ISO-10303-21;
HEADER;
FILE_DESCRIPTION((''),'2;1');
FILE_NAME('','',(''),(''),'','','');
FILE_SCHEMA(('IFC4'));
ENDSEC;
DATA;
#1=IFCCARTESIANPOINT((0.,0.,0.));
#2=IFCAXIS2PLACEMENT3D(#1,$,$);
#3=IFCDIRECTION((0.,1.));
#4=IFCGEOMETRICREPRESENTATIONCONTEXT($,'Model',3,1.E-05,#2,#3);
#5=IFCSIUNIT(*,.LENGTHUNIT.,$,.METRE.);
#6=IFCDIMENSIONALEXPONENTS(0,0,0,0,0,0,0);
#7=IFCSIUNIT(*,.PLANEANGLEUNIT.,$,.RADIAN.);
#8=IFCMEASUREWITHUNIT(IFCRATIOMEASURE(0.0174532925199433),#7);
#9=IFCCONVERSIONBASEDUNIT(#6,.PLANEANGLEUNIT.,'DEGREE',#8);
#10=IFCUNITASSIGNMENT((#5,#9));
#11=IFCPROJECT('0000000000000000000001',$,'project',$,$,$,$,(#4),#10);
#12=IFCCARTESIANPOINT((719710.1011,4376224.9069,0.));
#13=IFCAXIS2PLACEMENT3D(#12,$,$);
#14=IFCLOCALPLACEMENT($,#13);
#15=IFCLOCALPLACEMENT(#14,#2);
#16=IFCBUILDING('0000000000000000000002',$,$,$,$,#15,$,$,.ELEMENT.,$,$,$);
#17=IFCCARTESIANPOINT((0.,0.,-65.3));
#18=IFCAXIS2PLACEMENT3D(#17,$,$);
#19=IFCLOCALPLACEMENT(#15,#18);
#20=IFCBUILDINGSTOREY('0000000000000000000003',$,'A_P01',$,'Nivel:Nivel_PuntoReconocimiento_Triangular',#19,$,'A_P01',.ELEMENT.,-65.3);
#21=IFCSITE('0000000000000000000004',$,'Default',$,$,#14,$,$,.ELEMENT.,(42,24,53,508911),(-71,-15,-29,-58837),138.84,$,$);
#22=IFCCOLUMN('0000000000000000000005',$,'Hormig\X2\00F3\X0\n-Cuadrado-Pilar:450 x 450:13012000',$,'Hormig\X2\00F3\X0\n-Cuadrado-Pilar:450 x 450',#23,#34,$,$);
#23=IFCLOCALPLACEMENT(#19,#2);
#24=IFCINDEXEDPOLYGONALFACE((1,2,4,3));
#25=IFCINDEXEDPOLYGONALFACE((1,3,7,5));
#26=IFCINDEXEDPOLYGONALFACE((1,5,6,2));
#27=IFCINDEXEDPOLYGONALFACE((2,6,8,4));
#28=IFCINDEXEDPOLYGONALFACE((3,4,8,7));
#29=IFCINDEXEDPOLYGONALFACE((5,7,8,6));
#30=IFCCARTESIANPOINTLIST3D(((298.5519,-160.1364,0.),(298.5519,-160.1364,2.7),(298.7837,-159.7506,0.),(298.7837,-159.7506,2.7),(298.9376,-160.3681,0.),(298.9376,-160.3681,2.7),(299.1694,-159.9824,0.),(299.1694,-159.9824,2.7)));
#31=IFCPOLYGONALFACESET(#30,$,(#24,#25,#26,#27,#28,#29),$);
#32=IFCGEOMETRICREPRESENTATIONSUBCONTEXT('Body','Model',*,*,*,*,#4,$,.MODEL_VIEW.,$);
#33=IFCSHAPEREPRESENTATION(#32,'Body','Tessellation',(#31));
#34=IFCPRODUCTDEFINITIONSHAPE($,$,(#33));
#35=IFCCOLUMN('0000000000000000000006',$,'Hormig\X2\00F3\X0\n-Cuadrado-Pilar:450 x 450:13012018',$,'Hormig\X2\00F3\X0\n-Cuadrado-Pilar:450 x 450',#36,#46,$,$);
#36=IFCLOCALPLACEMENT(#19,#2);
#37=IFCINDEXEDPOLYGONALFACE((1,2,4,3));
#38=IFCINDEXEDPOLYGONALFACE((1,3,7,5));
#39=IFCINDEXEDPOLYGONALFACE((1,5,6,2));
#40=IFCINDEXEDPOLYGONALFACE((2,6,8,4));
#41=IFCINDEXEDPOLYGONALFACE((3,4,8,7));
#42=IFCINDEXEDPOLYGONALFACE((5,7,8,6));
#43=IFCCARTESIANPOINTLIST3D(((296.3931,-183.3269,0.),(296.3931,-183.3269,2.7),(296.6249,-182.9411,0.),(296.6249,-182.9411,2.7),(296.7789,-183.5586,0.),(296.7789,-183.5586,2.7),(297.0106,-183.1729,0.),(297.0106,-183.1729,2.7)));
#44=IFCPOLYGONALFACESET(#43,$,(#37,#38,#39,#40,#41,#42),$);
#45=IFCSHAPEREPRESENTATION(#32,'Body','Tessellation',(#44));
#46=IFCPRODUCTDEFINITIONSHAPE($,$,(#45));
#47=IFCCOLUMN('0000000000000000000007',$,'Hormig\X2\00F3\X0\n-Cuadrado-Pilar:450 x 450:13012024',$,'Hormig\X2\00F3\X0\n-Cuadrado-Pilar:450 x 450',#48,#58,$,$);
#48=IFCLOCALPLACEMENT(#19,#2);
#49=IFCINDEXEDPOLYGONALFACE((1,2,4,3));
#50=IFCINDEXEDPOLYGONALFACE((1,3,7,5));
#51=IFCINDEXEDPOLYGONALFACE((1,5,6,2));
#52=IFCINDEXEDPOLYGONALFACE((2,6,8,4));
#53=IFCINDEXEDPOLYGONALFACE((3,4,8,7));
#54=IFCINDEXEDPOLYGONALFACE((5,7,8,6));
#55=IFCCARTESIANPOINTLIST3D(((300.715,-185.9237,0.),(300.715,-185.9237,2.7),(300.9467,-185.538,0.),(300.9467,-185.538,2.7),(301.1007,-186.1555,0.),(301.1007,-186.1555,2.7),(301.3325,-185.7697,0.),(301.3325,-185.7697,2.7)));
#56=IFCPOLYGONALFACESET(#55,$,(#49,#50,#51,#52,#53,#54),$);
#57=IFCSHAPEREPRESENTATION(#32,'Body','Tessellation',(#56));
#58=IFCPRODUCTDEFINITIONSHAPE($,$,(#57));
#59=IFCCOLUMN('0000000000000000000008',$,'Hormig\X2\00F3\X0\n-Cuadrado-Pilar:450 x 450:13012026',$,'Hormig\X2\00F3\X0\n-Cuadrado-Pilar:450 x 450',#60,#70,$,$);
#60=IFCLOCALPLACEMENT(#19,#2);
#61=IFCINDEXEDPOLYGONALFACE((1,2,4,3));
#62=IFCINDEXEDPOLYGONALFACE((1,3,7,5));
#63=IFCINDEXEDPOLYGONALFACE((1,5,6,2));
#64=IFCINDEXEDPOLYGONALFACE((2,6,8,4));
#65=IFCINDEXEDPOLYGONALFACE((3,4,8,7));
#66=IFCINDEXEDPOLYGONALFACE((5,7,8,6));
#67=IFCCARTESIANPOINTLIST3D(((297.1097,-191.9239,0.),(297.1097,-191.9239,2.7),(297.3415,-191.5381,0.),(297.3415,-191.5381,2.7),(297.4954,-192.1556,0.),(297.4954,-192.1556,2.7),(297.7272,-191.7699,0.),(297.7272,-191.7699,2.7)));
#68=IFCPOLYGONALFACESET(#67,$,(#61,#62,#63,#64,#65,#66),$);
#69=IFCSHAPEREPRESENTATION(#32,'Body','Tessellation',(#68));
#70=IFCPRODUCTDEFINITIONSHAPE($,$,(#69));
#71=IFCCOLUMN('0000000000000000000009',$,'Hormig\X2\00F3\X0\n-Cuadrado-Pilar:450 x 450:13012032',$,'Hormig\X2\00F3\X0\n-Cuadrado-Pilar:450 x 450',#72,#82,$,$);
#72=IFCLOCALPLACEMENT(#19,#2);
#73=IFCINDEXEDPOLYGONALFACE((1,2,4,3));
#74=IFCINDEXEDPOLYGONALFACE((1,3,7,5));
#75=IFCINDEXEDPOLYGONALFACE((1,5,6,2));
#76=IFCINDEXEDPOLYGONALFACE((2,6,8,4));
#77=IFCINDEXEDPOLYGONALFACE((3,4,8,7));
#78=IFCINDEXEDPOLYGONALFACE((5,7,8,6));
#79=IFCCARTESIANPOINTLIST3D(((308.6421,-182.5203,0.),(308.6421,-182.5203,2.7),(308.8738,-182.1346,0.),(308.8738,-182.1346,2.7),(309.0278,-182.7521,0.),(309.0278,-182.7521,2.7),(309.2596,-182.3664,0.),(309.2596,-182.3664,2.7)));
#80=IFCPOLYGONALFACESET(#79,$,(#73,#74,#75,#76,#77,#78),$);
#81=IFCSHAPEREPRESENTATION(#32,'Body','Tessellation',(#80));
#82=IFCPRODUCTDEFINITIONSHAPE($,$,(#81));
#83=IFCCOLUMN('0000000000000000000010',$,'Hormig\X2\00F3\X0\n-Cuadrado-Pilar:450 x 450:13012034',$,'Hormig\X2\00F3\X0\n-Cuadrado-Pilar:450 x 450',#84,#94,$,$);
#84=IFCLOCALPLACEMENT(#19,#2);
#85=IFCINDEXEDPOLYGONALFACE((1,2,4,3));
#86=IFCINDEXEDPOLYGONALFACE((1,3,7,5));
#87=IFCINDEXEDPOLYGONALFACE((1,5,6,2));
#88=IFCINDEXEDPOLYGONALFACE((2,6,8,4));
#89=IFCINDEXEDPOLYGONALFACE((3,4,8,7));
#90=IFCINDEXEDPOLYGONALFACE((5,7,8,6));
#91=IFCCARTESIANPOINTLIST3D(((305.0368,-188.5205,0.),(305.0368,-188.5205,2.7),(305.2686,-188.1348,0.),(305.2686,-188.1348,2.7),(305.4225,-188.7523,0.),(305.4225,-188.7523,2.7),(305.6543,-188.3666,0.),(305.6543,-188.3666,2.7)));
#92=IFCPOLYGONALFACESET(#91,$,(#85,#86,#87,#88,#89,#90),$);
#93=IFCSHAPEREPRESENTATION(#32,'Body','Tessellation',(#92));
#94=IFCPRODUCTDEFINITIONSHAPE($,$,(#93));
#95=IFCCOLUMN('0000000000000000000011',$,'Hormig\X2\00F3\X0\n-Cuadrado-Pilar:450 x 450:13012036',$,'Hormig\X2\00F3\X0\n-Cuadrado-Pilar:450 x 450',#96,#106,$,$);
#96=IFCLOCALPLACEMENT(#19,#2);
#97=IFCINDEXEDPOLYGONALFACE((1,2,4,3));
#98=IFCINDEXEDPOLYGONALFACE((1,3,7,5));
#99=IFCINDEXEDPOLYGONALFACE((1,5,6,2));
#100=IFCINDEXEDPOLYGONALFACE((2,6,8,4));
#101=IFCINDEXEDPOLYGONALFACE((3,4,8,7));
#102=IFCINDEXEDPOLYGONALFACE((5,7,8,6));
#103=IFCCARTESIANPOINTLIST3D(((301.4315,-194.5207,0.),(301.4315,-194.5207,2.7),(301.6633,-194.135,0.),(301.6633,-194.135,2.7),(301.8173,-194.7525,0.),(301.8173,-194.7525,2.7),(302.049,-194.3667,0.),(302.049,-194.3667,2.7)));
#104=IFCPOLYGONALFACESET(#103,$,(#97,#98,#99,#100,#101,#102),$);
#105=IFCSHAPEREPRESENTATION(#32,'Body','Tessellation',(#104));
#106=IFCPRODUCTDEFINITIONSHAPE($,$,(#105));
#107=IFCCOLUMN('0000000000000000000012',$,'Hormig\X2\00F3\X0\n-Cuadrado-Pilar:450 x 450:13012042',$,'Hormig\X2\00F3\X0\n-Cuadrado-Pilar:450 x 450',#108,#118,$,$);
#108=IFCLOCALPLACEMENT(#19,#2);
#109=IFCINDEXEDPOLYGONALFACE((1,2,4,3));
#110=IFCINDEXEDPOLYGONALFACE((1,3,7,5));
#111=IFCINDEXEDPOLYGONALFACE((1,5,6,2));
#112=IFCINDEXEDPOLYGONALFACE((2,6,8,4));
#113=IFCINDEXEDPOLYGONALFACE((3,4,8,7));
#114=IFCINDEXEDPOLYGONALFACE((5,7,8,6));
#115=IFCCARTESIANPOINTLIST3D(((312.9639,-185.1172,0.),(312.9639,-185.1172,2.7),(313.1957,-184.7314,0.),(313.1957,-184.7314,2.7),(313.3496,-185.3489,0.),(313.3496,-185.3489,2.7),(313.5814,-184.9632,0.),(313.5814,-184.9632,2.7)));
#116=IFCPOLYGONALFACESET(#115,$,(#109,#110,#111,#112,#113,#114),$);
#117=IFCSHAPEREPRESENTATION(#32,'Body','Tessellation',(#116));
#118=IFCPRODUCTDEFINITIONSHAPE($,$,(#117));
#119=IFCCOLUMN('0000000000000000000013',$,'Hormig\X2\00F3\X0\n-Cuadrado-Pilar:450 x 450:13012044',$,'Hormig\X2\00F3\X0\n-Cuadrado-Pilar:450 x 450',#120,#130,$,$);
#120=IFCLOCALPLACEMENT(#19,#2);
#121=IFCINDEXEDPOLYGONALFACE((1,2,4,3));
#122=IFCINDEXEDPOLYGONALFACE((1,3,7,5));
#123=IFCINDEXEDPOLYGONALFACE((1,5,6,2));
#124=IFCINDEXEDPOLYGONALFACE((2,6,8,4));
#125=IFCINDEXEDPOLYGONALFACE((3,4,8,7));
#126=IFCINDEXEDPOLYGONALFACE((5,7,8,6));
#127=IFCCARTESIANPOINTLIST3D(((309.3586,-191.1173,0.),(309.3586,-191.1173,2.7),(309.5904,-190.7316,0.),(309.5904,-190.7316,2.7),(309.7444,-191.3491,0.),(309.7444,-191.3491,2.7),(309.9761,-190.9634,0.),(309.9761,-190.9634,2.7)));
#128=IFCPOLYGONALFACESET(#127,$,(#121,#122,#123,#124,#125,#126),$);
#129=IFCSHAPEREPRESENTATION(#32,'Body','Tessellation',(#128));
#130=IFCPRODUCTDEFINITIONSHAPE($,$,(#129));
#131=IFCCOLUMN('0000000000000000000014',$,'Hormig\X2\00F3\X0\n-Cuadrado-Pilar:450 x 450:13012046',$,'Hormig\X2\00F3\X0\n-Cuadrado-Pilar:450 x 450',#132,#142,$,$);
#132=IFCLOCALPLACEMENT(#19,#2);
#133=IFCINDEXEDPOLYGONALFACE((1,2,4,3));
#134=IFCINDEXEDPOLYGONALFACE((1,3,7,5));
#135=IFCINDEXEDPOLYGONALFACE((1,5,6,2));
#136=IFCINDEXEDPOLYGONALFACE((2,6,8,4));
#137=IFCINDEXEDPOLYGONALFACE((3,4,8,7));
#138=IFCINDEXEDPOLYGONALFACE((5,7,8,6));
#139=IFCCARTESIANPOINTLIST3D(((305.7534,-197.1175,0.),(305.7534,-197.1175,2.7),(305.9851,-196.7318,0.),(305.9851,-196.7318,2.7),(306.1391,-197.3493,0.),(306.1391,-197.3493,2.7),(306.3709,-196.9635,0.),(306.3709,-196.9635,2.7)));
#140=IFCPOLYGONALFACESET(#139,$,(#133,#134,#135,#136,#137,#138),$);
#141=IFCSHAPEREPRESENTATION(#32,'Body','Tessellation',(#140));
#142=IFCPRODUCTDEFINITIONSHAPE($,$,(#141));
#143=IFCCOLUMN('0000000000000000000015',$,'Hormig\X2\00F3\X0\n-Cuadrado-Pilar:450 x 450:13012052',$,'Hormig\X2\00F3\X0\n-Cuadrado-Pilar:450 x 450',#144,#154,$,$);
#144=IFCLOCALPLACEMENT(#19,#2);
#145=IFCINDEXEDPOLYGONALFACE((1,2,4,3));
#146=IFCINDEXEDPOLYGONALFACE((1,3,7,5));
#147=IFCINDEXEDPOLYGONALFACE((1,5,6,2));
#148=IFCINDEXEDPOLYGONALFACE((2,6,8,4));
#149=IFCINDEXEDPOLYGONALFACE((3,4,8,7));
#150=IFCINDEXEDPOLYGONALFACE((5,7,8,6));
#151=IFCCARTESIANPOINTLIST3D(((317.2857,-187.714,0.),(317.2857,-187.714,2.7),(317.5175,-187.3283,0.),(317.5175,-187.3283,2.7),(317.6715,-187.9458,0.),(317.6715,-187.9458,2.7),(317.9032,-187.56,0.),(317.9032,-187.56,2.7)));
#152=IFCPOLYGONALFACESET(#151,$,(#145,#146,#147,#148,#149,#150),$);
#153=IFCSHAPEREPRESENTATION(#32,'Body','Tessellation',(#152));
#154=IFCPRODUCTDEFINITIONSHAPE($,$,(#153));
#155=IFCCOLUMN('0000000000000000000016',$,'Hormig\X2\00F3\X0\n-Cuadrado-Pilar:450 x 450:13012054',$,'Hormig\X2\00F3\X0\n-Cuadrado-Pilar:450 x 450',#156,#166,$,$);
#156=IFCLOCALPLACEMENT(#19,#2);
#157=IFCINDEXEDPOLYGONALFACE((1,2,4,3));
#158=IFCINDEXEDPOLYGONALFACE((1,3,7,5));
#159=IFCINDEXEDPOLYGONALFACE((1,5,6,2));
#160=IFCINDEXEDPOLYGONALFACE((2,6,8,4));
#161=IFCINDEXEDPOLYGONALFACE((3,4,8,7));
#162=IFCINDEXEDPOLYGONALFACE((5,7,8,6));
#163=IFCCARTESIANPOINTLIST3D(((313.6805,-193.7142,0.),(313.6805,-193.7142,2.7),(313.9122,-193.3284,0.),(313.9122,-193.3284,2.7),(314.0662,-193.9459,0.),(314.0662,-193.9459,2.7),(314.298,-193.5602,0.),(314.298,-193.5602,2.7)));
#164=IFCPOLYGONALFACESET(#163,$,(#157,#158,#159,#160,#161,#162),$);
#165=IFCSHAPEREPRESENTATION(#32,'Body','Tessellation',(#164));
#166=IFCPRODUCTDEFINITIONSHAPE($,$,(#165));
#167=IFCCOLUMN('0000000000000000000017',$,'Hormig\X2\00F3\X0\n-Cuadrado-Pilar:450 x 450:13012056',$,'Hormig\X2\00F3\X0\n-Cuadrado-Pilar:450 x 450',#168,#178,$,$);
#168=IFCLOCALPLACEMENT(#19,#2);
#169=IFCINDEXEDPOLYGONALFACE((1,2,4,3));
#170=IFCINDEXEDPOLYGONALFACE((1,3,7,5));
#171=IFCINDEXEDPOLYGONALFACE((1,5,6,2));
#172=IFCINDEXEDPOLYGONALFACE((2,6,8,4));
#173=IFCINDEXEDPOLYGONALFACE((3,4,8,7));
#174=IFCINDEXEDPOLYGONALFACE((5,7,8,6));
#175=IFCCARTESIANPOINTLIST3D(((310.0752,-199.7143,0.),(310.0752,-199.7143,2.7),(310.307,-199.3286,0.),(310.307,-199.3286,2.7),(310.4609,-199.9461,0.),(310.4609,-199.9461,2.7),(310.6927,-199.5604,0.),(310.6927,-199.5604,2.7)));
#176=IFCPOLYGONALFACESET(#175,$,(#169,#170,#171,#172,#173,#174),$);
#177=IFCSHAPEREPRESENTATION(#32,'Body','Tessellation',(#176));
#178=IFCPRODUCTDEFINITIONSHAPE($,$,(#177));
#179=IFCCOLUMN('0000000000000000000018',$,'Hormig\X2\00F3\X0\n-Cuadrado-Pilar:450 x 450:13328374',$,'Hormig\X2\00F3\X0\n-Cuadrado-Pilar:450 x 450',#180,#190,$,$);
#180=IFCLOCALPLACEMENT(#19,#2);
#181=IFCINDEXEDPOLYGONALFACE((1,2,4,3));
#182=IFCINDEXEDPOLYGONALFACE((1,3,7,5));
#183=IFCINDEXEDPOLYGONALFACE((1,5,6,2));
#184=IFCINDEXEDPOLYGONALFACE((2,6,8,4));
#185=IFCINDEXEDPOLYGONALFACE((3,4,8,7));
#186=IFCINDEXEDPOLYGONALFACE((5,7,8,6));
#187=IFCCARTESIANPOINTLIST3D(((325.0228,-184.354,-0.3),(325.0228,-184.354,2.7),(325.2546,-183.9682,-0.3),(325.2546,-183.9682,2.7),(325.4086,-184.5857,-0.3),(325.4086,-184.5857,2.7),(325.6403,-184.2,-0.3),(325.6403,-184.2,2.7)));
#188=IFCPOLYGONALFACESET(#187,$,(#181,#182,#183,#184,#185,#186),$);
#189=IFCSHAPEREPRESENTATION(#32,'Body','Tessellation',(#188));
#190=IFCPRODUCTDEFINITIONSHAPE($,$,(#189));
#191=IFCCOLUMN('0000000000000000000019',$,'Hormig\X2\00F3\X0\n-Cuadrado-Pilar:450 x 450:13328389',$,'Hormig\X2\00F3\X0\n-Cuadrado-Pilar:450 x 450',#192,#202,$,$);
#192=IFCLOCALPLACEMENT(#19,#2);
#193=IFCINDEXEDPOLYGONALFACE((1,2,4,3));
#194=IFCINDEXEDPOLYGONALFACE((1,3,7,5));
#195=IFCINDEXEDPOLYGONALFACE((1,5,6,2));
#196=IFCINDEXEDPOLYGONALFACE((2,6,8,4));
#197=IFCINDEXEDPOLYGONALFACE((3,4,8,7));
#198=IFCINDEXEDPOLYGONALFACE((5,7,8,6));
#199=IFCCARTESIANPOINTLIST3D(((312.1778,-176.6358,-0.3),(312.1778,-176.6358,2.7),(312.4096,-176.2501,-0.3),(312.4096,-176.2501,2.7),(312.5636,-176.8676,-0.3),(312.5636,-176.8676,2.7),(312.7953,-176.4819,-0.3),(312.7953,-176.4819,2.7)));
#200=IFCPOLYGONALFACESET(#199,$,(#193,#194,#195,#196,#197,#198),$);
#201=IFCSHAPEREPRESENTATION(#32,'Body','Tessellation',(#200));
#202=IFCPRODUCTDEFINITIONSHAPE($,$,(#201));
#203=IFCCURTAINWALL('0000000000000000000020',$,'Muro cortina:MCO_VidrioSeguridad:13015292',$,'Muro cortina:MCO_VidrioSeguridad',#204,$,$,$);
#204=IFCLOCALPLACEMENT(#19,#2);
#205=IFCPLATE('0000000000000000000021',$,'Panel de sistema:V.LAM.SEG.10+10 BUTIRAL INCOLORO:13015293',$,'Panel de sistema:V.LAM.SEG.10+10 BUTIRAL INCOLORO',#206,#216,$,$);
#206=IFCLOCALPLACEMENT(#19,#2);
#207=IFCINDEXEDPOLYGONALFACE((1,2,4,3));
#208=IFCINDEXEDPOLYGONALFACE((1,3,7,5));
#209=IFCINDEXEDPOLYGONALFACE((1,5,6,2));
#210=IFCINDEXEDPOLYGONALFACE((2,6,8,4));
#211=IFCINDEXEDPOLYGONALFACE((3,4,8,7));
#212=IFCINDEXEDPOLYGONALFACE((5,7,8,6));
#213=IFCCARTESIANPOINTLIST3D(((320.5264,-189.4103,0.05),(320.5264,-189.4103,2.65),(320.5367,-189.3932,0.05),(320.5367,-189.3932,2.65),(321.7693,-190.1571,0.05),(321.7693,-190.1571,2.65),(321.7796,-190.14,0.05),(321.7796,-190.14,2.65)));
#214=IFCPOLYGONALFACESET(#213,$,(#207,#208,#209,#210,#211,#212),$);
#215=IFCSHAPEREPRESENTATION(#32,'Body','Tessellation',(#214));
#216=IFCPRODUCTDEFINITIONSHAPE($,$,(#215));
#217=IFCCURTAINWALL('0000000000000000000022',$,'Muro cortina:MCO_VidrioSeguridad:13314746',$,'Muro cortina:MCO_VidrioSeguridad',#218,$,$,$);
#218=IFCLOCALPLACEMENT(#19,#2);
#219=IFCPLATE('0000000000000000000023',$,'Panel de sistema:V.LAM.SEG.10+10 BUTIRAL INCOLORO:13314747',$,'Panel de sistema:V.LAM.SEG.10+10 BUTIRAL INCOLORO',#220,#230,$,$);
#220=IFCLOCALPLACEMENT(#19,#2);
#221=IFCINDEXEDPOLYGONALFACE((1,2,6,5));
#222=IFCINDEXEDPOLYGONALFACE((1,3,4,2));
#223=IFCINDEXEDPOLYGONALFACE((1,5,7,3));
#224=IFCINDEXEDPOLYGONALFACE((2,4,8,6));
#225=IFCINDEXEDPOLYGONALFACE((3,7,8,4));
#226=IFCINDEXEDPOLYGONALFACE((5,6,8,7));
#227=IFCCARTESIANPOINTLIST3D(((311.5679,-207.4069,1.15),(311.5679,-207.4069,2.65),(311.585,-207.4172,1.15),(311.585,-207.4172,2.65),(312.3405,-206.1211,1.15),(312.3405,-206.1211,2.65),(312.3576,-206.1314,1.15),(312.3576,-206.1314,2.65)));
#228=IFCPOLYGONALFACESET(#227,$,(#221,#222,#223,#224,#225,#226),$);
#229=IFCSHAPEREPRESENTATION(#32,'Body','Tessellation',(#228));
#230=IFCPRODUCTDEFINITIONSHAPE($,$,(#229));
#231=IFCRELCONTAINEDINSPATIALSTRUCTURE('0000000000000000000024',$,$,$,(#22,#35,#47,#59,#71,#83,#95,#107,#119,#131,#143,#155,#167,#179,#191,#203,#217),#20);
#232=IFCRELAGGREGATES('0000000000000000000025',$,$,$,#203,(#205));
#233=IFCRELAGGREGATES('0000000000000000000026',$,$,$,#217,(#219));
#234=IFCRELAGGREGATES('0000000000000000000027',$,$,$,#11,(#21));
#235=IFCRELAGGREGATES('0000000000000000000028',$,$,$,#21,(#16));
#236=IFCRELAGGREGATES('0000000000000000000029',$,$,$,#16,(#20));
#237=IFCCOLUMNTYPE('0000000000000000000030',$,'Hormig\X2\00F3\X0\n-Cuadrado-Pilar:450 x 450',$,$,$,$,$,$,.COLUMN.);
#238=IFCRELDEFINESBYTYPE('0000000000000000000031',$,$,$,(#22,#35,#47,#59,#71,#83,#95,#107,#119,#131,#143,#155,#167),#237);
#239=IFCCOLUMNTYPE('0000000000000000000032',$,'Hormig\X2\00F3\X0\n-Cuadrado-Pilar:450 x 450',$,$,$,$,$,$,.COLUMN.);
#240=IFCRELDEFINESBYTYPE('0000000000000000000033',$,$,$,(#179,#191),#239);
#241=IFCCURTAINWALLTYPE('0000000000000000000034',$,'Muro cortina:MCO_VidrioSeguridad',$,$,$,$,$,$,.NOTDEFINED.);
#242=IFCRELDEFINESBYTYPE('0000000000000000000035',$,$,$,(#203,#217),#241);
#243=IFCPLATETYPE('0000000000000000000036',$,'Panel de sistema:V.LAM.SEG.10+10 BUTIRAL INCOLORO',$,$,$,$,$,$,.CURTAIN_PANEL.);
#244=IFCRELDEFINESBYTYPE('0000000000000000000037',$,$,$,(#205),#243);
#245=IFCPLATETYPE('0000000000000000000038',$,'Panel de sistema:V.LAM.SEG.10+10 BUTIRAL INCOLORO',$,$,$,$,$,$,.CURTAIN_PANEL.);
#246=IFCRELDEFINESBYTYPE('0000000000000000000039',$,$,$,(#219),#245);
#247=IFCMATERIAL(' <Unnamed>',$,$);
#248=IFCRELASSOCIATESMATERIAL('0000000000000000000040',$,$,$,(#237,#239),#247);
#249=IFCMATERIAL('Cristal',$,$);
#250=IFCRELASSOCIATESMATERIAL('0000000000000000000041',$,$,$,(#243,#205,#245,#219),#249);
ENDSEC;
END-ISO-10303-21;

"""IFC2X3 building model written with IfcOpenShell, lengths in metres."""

from ifc_helpers import new_model, entity, si_unit, converted_unit, direction, frame, frame_2d, origin, origin_2d_with_axis, place, context, subcontext, project, spatial, rectangle, extrude, source, transform, mapped, material, type_object, type_shapes, element, aggregate, save


model = new_model("IFC2X3")

# Units and contexts
model_context = context("Model", 3, precision=1e-05, world=origin(), true_north=direction((0.0, 1.0)))
body_context = subcontext(model_context, "Body", "Model", "MODEL_VIEW")
ifc_project = project(units=[si_unit("LENGTHUNIT", "METRE"), converted_unit("PLANEANGLEUNIT", "DEGREE", entity("IfcRatioMeasure", 0.0174532925199433), si_unit("PLANEANGLEUNIT", "RADIAN"), dimensions=[0, 0, 0, 0, 0, 0, 0])], contexts=[model_context])

# Site, building, storey
site_placement = place(None, frame((719710.1011, 4376224.9069, 0.0)))
site = spatial("IfcSite", under=ifc_project, at=site_placement, Name="Default", CompositionType="ELEMENT", RefLatitude=(42, 24, 53, 508911), RefLongitude=(-71, -15, -29, -58837), RefElevation=138.84)
building_placement = place(site_placement, origin())
building = spatial("IfcBuilding", under=site, at=building_placement, CompositionType="ELEMENT")
storey_placement = place(building_placement, frame((0.0, 0.0, -65.3)))
storey = spatial("IfcBuildingStorey", under=building, at=storey_placement, Name="A_P01", ObjectType="Nivel:Nivel_PuntoReconocimiento_Triangular", LongName="A_P01", CompositionType="ELEMENT", Elevation=-65.3)

# Columns
ifc_material_1 = material(Name=" <Unnamed>")
column_type_1 = type_object("IfcColumnType", Name="Hormigón-Cuadrado-Pilar:450 x 450", PredefinedType="COLUMN", material=ifc_material_1)
shared_shape_1 = source(origin(), body_context, "Body", "SweptSolid", [
    extrude(rectangle(XDim=0.45, YDim=0.45, at=origin_2d_with_axis()), frame((0.0, 0.0, -65.3), z_axis=(0.0, 0.0, 1.0), x_axis=(0.0, -1.0, 0.0)), (0.0, 0.0, 1.0), 2.7),
])
type_shapes(column_type_1, [shared_shape_1])
for number, where, z_axis, x_axis, name in (
    (1, (298.8607, -160.0594, 65.3), (0.0, 0.0, 1.0), (0.857167, -0.515038, 0.0), "Hormigón-Cuadrado-Pilar:450 x 450:13012000"),
    (2, (296.7019, -183.2499, 65.3), (0.0, 0.0, 1.0), (0.857167, -0.515038, 0.0), "Hormigón-Cuadrado-Pilar:450 x 450:13012018"),
    (3, (301.0237, -185.8467, 65.3), (0.0, 0.0, 1.0), (0.857167, -0.515038, 0.0), "Hormigón-Cuadrado-Pilar:450 x 450:13012024"),
    (4, (297.4184, -191.8469, 65.3), (0.0, 0.0, 1.0), (0.857167, -0.515038, 0.0), "Hormigón-Cuadrado-Pilar:450 x 450:13012026"),
    (5, (308.9508, -182.4434, 65.3), (0.0, 0.0, 1.0), (0.857167, -0.515038, 0.0), "Hormigón-Cuadrado-Pilar:450 x 450:13012032"),
    (6, (305.3456, -188.4435, 65.3), (0.0, 0.0, 1.0), (0.857167, -0.515038, 0.0), "Hormigón-Cuadrado-Pilar:450 x 450:13012034"),
    (7, (301.7403, -194.4437, 65.3), (0.0, 0.0, 1.0), (0.857167, -0.515038, 0.0), "Hormigón-Cuadrado-Pilar:450 x 450:13012036"),
    (8, (313.2727, -185.0402, 65.3), (0.0, 0.0, 1.0), (0.857167, -0.515038, 0.0), "Hormigón-Cuadrado-Pilar:450 x 450:13012042"),
    (9, (309.6674, -191.0404, 65.3), (0.0, 0.0, 1.0), (0.857167, -0.515038, 0.0), "Hormigón-Cuadrado-Pilar:450 x 450:13012044"),
    (10, (306.0621, -197.0405, 65.3), (0.0, 0.0, 1.0), (0.857167, -0.515038, 0.0), "Hormigón-Cuadrado-Pilar:450 x 450:13012046"),
    (11, (317.5945, -187.637, 65.3), (0.0, 0.0, 1.0), (0.857167, -0.515038, 0.0), "Hormigón-Cuadrado-Pilar:450 x 450:13012052"),
    (12, (313.9892, -193.6372, 65.3), (0.0, 0.0, 1.0), (0.857167, -0.515038, 0.0), "Hormigón-Cuadrado-Pilar:450 x 450:13012054"),
    (13, (310.384, -199.6373, 65.3), (0.0, 0.0, 1.0), (0.857167, -0.515038, 0.0), "Hormigón-Cuadrado-Pilar:450 x 450:13012056"),
):
    element("IfcColumn", number, at=place(storey_placement, frame(where, z_axis=z_axis, x_axis=x_axis)), inside=storey, type_object=column_type_1, Name=name, ObjectType="Hormigón-Cuadrado-Pilar:450 x 450", context=body_context, shape_type="MappedRepresentation", body=[
        mapped(shared_shape_1, transform((0.0, 0.0, 0.0), scale=1.0)),
    ])
column_type_2 = type_object("IfcColumnType", Name="Hormigón-Cuadrado-Pilar:450 x 450", PredefinedType="COLUMN", material=ifc_material_1)
shared_shape_2 = source(origin(), body_context, "Body", "SweptSolid", [
    extrude(rectangle(XDim=0.45, YDim=0.45, at=origin_2d_with_axis()), frame((0.0, 0.0, -65.6), z_axis=(0.0, 0.0, 1.0), x_axis=(0.0, -1.0, 0.0)), (0.0, 0.0, 1.0), 3.0),
])
type_shapes(column_type_2, [shared_shape_2])
for number, where, z_axis, x_axis, name in (
    (14, (325.3316, -184.277, 65.3), (0.0, 0.0, 1.0), (0.857167, -0.515038, 0.0), "Hormigón-Cuadrado-Pilar:450 x 450:13328374"),
    (15, (312.4866, -176.5589, 65.3), (0.0, 0.0, 1.0), (-0.515038, -0.857167, 0.0), "Hormigón-Cuadrado-Pilar:450 x 450:13328389"),
):
    element("IfcColumn", number, at=place(storey_placement, frame(where, z_axis=z_axis, x_axis=x_axis)), inside=storey, type_object=column_type_2, Name=name, ObjectType="Hormigón-Cuadrado-Pilar:450 x 450", context=body_context, shape_type="MappedRepresentation", body=[
        mapped(shared_shape_2, transform((0.0, 0.0, 0.0), scale=1.0)),
    ])

# Curtain wall, plate
curtain_wall_type = type_object("IfcCurtainWallType", Name="Muro cortina:MCO_VidrioSeguridad", PredefinedType="NOTDEFINED")
curtain_wall_1_placement = place(storey_placement, frame((0.0, 0.0, 65.3)))
curtain_wall_1 = element("IfcCurtainWall", 16, at=curtain_wall_1_placement, inside=storey, type_object=curtain_wall_type, Name="Muro cortina:MCO_VidrioSeguridad:13015292", ObjectType="Muro cortina:MCO_VidrioSeguridad")
ifc_material_2 = material(Name="Cristal")
plate_type_1 = type_object("IfcPlateType", Name="Panel de sistema:V.LAM.SEG.10+10 BUTIRAL INCOLORO", PredefinedType="CURTAIN_PANEL", material=ifc_material_2)
shared_shape_3 = source(origin(), body_context, "Body", "SweptSolid", [
    extrude(rectangle(XDim=0.02, YDim=1.45, at=origin_2d_with_axis()), frame((0.0, 0.0, 0.0), z_axis=(0.0, 0.0, 1.0), x_axis=(0.0, 1.0, 0.0)), (0.0, 0.0, 1.0), 2.6),
])
type_shapes(plate_type_1, [shared_shape_3])
plate_1_placement = place(curtain_wall_1_placement, frame((321.153, -189.7752, -65.25), z_axis=(0.0, 0.0, 1.0), x_axis=(-0.857167, 0.515038, 0.0)))
plate_1 = element("IfcPlate", 17, at=plate_1_placement, type_object=plate_type_1, material=ifc_material_2, Name="Panel de sistema:V.LAM.SEG.10+10 BUTIRAL INCOLORO:13015293", ObjectType="Panel de sistema:V.LAM.SEG.10+10 BUTIRAL INCOLORO", context=body_context, shape_type="MappedRepresentation", body=[
    mapped(shared_shape_3, transform((0.0, 0.0, 0.0), scale=1.0)),
])
aggregate(curtain_wall_1, [plate_1])

# Curtain wall, plate
curtain_wall_2_placement = place(storey_placement, frame((0.0, 0.0, 65.3)))
curtain_wall_2 = element("IfcCurtainWall", 18, at=curtain_wall_2_placement, inside=storey, type_object=curtain_wall_type, Name="Muro cortina:MCO_VidrioSeguridad:13314746", ObjectType="Muro cortina:MCO_VidrioSeguridad")
plate_type_2 = type_object("IfcPlateType", Name="Panel de sistema:V.LAM.SEG.10+10 BUTIRAL INCOLORO", PredefinedType="CURTAIN_PANEL", material=ifc_material_2)
shared_shape_4 = source(origin(), body_context, "Body", "SweptSolid", [
    extrude(rectangle(XDim=0.02, YDim=1.5, at=frame_2d((0.0, 0.0), x_axis=(1.0, 0.0))), frame((0.0, 0.0, 0.0), z_axis=(0.0, 0.0, 1.0), x_axis=(0.0, 1.0, 0.0)), (0.0, 0.0, 1.0), 1.5),
])
type_shapes(plate_type_2, [shared_shape_4])
plate_2_placement = place(curtain_wall_2_placement, frame((311.9628, -206.7691, -64.15), z_axis=(0.0, 0.0, 1.0), x_axis=(0.515038, 0.857167, 0.0)))
plate_2 = element("IfcPlate", 19, at=plate_2_placement, type_object=plate_type_2, material=ifc_material_2, Name="Panel de sistema:V.LAM.SEG.10+10 BUTIRAL INCOLORO:13314747", ObjectType="Panel de sistema:V.LAM.SEG.10+10 BUTIRAL INCOLORO", context=body_context, shape_type="MappedRepresentation", body=[
    mapped(shared_shape_4, transform((0.0, 0.0, 0.0), scale=1.0)),
])

aggregate(curtain_wall_2, [plate_2])

save(model, "model.ifc")
